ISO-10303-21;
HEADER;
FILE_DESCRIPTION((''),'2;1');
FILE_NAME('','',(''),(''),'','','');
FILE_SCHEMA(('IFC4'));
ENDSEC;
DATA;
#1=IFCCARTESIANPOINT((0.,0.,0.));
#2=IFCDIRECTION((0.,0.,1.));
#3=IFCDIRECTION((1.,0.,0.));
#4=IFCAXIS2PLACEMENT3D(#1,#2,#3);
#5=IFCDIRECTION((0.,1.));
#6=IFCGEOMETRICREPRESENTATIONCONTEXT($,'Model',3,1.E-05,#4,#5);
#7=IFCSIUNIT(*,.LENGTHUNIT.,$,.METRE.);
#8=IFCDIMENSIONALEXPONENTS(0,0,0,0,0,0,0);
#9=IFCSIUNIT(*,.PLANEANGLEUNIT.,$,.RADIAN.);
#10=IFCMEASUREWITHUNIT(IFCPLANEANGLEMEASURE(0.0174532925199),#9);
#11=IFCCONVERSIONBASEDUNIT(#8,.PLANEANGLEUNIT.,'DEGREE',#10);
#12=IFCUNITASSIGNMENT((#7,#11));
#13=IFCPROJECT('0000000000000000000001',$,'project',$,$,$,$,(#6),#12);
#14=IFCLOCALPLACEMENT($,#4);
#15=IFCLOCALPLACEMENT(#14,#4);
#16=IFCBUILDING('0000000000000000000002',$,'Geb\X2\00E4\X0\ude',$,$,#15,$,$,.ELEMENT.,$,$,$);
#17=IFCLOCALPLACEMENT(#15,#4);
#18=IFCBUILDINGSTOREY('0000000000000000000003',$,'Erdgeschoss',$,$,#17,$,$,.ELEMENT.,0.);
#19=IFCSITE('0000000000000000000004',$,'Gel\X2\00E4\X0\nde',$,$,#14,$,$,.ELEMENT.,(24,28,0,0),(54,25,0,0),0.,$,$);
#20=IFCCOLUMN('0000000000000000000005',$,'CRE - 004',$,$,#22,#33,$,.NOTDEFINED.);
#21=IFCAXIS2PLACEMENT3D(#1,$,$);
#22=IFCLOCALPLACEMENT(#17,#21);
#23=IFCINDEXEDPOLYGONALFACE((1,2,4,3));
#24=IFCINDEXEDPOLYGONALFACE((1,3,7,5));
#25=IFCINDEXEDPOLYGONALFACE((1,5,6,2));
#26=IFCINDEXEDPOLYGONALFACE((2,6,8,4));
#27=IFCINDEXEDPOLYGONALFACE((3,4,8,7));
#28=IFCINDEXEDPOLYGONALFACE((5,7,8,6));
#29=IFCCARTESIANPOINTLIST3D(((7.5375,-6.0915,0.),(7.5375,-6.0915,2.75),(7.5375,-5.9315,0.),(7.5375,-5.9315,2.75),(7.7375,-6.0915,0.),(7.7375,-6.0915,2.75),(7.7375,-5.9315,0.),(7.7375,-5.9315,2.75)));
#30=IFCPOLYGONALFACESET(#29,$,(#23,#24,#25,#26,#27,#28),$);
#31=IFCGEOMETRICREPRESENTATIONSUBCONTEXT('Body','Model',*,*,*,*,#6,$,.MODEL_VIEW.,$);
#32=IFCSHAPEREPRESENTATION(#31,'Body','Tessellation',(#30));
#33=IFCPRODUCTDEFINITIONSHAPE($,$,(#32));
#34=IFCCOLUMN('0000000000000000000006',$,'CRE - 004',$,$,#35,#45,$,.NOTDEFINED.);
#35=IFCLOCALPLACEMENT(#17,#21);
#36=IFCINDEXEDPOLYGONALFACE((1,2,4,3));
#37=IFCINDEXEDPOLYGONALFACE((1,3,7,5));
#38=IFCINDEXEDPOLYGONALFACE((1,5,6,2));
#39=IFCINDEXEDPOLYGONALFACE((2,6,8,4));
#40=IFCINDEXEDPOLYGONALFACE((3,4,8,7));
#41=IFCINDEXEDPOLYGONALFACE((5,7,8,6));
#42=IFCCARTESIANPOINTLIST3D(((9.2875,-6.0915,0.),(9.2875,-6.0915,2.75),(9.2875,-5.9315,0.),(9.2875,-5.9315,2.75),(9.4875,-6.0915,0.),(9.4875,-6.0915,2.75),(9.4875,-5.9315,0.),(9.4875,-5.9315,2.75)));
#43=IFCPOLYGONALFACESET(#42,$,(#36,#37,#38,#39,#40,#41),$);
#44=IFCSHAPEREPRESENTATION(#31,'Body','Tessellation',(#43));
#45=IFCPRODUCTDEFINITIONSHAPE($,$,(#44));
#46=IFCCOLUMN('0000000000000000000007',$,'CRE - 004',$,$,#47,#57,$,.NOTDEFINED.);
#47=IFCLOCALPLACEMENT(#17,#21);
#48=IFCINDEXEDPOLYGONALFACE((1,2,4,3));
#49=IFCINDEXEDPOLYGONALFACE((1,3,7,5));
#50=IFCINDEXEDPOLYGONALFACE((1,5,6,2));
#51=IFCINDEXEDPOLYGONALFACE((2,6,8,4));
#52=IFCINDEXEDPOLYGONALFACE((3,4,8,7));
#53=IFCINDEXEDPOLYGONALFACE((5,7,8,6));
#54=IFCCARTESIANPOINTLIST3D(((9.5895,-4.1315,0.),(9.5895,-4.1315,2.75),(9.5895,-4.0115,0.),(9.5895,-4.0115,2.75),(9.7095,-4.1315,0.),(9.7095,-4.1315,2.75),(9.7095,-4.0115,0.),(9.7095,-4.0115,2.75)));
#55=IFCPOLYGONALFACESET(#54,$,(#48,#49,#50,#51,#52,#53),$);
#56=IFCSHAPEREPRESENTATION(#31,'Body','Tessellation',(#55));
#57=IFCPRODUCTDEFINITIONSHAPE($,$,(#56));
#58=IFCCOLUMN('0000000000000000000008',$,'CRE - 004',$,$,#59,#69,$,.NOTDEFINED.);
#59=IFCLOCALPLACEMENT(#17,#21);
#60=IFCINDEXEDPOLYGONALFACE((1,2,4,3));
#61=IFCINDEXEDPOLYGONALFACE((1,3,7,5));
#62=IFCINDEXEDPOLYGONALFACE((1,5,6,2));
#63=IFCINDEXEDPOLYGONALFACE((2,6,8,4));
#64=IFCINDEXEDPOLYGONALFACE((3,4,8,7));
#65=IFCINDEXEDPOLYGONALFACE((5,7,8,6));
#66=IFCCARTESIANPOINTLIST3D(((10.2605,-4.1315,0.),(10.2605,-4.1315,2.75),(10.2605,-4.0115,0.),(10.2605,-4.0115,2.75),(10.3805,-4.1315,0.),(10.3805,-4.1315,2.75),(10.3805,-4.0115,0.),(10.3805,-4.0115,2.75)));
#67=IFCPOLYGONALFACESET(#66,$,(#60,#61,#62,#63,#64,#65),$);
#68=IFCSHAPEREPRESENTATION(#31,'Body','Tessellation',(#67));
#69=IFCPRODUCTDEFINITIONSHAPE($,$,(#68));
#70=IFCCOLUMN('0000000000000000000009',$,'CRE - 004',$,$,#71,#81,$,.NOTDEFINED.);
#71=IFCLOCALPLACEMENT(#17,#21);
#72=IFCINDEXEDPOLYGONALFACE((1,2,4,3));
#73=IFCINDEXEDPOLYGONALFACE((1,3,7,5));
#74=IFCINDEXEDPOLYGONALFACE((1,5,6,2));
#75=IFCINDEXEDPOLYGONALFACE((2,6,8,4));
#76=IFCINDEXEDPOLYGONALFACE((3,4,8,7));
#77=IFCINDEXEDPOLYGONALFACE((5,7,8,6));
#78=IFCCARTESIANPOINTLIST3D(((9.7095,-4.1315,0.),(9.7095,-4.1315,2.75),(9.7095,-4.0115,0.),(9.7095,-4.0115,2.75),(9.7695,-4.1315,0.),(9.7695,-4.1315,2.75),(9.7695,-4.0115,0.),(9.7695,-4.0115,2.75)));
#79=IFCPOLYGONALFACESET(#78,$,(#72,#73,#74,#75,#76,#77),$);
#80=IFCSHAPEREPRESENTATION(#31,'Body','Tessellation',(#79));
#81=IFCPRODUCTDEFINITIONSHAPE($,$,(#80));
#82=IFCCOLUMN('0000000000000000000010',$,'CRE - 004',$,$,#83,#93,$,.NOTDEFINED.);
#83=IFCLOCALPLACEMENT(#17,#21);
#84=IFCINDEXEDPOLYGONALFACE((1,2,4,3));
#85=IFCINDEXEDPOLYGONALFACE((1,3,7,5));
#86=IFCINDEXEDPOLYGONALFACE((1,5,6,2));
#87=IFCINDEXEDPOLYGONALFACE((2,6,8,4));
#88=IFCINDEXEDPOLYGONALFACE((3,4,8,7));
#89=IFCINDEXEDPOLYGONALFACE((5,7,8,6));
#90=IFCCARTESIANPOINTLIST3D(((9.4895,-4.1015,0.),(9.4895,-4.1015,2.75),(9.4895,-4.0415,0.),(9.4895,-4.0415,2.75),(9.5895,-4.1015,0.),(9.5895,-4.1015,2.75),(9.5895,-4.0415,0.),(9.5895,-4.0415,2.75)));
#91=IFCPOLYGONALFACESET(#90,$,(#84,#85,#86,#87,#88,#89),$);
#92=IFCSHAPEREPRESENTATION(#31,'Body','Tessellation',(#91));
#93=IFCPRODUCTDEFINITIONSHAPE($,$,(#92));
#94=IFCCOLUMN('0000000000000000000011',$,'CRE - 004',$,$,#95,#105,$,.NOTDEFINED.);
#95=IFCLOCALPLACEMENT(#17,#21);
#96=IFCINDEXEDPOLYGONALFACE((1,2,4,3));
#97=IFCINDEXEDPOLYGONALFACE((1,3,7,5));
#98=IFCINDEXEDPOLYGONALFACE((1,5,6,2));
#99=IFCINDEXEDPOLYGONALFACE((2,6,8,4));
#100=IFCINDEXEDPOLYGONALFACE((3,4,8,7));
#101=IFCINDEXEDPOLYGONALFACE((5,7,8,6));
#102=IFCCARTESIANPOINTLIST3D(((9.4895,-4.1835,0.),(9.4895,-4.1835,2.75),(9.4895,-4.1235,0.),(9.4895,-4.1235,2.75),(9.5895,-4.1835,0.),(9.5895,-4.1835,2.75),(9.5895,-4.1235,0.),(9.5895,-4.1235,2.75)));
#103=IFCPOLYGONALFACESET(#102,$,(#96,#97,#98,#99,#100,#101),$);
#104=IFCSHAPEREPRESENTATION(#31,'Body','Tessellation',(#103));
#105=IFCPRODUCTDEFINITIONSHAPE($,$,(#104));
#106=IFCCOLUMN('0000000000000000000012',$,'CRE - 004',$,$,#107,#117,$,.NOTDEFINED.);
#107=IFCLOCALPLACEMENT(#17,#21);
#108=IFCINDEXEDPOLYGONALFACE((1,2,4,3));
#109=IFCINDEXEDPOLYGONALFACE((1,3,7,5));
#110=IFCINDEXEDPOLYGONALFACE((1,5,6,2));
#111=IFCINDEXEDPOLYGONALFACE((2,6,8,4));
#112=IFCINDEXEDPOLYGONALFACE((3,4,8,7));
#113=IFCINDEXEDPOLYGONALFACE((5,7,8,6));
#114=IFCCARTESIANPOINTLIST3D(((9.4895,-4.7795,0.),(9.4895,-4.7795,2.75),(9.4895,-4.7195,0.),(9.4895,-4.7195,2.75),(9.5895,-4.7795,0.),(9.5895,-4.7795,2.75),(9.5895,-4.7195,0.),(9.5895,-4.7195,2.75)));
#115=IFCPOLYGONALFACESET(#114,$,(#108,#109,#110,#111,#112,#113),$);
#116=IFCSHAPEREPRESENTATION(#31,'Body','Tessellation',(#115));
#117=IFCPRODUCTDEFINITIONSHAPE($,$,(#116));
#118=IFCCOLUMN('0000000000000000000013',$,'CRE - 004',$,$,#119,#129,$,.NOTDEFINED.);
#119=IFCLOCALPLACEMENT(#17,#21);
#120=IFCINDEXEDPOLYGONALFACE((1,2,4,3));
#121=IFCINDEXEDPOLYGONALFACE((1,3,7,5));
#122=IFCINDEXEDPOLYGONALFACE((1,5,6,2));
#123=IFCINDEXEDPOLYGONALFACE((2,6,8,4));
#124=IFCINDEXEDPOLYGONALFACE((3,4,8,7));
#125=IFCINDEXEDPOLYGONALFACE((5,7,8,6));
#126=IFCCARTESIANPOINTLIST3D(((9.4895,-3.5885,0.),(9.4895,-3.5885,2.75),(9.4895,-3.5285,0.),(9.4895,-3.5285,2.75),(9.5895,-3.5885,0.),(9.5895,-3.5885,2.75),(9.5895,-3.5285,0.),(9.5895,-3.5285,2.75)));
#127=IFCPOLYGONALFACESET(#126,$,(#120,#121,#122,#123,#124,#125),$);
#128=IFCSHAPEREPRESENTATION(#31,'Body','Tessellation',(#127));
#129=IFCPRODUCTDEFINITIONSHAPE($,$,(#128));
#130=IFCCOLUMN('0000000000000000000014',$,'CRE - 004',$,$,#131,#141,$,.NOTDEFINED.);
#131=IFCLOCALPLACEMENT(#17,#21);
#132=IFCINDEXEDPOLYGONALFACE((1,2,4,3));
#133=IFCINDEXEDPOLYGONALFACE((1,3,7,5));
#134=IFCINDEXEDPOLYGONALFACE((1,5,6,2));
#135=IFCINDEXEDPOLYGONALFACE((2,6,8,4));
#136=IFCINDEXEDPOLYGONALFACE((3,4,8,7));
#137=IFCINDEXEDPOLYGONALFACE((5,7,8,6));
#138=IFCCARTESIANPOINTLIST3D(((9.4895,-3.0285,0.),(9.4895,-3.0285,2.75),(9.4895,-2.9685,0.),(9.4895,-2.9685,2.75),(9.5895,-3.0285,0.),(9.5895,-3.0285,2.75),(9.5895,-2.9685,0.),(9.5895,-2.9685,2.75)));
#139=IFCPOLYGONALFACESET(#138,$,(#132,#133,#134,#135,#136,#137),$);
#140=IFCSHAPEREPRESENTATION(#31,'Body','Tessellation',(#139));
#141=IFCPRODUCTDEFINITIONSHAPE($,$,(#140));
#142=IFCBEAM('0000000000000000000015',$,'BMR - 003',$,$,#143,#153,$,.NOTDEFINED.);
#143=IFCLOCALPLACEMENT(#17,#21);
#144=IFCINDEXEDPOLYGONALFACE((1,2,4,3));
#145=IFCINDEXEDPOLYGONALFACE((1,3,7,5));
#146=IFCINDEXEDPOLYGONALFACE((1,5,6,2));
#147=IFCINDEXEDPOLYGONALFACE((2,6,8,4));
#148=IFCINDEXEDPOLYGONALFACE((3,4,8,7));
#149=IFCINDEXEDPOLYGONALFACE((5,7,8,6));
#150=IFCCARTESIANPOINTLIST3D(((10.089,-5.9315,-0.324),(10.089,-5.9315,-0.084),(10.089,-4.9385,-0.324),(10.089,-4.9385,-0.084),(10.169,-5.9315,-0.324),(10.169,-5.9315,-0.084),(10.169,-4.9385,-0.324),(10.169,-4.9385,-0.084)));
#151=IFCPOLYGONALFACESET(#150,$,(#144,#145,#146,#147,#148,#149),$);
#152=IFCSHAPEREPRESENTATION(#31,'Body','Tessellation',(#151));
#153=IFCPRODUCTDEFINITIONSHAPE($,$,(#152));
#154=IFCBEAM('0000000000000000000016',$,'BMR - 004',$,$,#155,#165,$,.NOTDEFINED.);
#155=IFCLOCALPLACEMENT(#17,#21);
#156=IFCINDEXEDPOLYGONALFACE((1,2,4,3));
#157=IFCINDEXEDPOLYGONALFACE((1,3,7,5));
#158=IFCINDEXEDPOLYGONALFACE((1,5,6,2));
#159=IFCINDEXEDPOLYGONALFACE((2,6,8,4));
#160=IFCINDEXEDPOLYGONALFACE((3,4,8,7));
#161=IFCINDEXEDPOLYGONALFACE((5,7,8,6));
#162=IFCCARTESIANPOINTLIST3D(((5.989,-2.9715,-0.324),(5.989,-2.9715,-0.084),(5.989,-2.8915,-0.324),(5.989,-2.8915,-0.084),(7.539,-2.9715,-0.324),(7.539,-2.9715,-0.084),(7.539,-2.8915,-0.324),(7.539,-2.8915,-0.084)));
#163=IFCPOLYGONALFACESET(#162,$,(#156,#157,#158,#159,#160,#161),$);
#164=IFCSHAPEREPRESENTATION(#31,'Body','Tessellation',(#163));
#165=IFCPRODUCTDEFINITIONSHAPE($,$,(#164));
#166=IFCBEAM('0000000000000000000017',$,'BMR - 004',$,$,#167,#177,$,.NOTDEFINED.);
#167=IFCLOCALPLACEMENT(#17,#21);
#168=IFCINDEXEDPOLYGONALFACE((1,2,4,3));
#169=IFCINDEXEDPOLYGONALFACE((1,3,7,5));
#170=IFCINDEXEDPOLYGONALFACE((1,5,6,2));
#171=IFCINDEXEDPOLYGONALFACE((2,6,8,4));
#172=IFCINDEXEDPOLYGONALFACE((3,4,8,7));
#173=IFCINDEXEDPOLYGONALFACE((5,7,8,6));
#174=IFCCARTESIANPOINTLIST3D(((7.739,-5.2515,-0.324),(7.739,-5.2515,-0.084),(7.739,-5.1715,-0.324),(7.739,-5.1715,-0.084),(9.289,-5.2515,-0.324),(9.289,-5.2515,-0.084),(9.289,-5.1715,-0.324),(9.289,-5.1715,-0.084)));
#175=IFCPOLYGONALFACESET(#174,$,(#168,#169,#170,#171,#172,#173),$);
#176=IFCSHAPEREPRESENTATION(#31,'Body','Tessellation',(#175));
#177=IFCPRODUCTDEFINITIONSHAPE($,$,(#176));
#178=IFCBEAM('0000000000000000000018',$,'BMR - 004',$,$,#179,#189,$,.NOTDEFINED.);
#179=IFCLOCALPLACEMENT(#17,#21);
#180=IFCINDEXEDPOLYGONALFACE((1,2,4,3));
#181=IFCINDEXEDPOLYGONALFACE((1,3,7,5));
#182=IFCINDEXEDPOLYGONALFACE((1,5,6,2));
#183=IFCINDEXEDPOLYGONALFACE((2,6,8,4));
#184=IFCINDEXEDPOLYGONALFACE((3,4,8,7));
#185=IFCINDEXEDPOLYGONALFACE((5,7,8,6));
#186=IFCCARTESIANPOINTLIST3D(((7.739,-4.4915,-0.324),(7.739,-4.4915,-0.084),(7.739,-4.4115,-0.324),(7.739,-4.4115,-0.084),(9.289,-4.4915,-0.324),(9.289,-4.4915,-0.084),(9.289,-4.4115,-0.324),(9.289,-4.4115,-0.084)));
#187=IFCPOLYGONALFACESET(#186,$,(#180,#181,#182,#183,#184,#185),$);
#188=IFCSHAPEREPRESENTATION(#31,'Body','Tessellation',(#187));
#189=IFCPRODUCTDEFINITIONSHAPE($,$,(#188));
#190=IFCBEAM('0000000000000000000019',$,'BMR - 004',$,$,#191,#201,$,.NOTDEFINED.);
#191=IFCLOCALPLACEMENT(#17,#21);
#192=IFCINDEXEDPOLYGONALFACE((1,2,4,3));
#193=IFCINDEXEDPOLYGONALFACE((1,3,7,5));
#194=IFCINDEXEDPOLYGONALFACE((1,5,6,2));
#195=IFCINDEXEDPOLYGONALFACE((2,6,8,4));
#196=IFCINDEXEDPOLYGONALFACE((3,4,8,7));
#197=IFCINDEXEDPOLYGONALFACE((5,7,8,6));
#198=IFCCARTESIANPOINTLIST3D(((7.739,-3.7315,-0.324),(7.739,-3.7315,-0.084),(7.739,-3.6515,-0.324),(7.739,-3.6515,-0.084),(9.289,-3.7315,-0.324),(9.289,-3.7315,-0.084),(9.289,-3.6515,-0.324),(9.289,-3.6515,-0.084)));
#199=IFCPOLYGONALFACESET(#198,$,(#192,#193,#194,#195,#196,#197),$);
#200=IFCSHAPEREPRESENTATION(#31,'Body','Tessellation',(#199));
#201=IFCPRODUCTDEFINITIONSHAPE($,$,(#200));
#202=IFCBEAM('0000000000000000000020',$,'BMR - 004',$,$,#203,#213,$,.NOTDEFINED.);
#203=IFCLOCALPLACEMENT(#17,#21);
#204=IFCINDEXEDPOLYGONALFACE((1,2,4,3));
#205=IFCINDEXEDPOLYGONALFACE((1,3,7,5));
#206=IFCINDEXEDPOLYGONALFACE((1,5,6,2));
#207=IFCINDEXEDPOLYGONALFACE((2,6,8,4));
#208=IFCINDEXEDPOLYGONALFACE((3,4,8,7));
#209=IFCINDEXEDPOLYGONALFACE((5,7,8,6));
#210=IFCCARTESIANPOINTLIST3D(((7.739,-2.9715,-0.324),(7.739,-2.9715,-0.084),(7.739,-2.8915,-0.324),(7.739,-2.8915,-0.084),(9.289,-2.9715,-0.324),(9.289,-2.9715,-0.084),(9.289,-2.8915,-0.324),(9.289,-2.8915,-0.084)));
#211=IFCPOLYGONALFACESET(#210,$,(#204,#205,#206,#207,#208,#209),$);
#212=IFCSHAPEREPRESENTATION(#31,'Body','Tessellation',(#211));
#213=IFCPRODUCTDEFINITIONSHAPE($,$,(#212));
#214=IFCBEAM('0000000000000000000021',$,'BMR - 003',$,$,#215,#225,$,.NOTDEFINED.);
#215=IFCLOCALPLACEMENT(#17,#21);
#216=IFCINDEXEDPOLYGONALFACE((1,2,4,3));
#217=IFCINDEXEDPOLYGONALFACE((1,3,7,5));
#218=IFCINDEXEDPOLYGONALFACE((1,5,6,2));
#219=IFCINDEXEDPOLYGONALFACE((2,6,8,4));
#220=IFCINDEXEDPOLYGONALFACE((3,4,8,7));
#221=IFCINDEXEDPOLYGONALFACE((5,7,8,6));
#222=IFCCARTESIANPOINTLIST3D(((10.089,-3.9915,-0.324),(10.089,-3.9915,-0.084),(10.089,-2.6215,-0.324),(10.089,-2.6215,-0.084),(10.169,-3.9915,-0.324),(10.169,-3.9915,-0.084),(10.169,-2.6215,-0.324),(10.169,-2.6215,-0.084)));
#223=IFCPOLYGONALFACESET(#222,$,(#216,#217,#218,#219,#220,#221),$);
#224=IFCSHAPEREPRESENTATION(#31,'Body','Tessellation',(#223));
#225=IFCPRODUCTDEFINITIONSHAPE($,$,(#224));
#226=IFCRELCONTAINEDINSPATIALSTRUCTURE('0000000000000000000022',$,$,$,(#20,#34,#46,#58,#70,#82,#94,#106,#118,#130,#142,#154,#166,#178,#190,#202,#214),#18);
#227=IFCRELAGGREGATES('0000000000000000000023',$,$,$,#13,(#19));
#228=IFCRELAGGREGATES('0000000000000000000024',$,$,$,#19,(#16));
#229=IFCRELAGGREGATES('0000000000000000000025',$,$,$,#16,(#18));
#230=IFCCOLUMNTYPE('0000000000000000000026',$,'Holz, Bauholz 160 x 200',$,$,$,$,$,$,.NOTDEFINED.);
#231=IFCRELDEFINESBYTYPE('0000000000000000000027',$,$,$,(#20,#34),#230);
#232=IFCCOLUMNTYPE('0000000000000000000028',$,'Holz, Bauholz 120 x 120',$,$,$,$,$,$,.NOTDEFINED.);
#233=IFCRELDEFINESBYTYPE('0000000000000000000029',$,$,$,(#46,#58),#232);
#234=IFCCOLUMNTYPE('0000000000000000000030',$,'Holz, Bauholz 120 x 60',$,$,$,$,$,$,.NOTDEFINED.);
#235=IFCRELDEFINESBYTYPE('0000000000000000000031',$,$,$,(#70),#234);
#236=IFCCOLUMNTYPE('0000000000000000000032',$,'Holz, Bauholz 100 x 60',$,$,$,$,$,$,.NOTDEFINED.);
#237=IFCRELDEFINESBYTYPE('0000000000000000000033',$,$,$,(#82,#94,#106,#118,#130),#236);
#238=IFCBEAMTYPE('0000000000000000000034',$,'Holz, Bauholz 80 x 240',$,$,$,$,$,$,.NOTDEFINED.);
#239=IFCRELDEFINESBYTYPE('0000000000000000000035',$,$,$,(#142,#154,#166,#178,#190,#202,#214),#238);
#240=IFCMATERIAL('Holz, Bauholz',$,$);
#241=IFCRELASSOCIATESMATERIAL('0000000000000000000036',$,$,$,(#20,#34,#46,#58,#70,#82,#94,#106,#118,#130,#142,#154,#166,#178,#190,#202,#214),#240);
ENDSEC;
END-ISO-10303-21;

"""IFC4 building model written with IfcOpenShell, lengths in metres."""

from ifc_helpers import new_model, entity, si_unit, converted_unit, direction, frame, frame_2d, origin_with_axes, origin_2d_with_axis, place, context, subcontext, project, spatial, rectangle, extrude, material, type_object, element, save


model = new_model("IFC4")

# Units and contexts
model_context = context("Model", 3, precision=1e-05, world=origin_with_axes(), true_north=direction((0.0, 1.0)))
body_context = subcontext(model_context, "Body", "Model", "MODEL_VIEW")
ifc_project = project(units=[si_unit("LENGTHUNIT", "METRE"), converted_unit("PLANEANGLEUNIT", "DEGREE", entity("IfcPlaneAngleMeasure", 0.0174532925199), si_unit("PLANEANGLEUNIT", "RADIAN"), dimensions=[0, 0, 0, 0, 0, 0, 0])], contexts=[model_context])

# Site, building, storey
site_placement = place(None, origin_with_axes())
site = spatial("IfcSite", under=ifc_project, at=site_placement, Name="Gelände", CompositionType="ELEMENT", RefLatitude=(24, 28, 0, 0), RefLongitude=(54, 25, 0, 0), RefElevation=0.0)
building_placement = place(site_placement, origin_with_axes())
building = spatial("IfcBuilding", under=site, at=building_placement, Name="Gebäude", CompositionType="ELEMENT")
storey_placement = place(building_placement, origin_with_axes())
storey = spatial("IfcBuildingStorey", under=building, at=storey_placement, Name="Erdgeschoss", CompositionType="ELEMENT", Elevation=0.0)

# Columns
ifc_material_1 = material(Name="Holz, Bauholz")
column_type_1 = type_object("IfcColumnType", Name="Holz, Bauholz 160 x 200", PredefinedType="NOTDEFINED")
for number, where, z_axis, x_axis, name in (
    (1, (7.6375, -6.0115, 0.0), (0.0, 0.0, 1.0), (1.0, 0.0, 0.0), "CRE - 004"),
    (2, (9.3875, -6.0115, 0.0), (0.0, 0.0, 1.0), (1.0, 0.0, 0.0), "CRE - 004"),
):
    element("IfcColumn", number, at=place(storey_placement, frame(where, z_axis=z_axis, x_axis=x_axis)), inside=storey, type_object=column_type_1, material=ifc_material_1, Name=name, PredefinedType="NOTDEFINED", context=body_context, shape_type="SweptSolid", body=[
        extrude(rectangle(XDim=0.16, YDim=0.2, at=origin_2d_with_axis()), frame((0.0, 0.0, 0.0), z_axis=(0.0, 0.0, 1.0), x_axis=(0.0, 1.0, 0.0)), (0.0, 0.0, 1.0), 2.75),
    ])
column_type_2 = type_object("IfcColumnType", Name="Holz, Bauholz 120 x 120", PredefinedType="NOTDEFINED")
for number, where, z_axis, x_axis, name in (
    (3, (9.6495, -4.0715, 0.0), (0.0, 0.0, 1.0), (1.0, 0.0, 0.0), "CRE - 004"),
    (4, (10.3205, -4.0715, 0.0), (0.0, 0.0, 1.0), (1.0, 0.0, 0.0), "CRE - 004"),
):
    element("IfcColumn", number, at=place(storey_placement, frame(where, z_axis=z_axis, x_axis=x_axis)), inside=storey, type_object=column_type_2, material=ifc_material_1, Name=name, PredefinedType="NOTDEFINED", context=body_context, shape_type="SweptSolid", body=[
        extrude(rectangle(XDim=0.12, YDim=0.12, at=origin_2d_with_axis()), frame((0.0, 0.0, 0.0), z_axis=(0.0, 0.0, 1.0), x_axis=(0.0, 1.0, 0.0)), (0.0, 0.0, 1.0), 2.75),
    ])
column_type_3 = type_object("IfcColumnType", Name="Holz, Bauholz 120 x 60", PredefinedType="NOTDEFINED")
column_placement = place(storey_placement, frame((9.7395, -4.0715, 0.0), z_axis=(0.0, 0.0, 1.0), x_axis=(1.0, 0.0, 0.0)))
element("IfcColumn", 5, at=column_placement, inside=storey, type_object=column_type_3, material=ifc_material_1, Name="CRE - 004", PredefinedType="NOTDEFINED", context=body_context, shape_type="SweptSolid", body=[
    extrude(rectangle(XDim=0.12, YDim=0.06, at=origin_2d_with_axis()), frame((0.0, 0.0, 0.0), z_axis=(0.0, 0.0, 1.0), x_axis=(0.0, 1.0, 0.0)), (0.0, 0.0, 1.0), 2.75),
])
column_type_4 = type_object("IfcColumnType", Name="Holz, Bauholz 100 x 60", PredefinedType="NOTDEFINED")
for number, where, z_axis, x_axis, name in (
    (6, (9.5395, -4.0715, 0.0), (0.0, 0.0, 1.0), (0.0, -1.0, 0.0), "CRE - 004"),
    (7, (9.5395, -4.1535, 0.0), (0.0, 0.0, 1.0), (0.0, -1.0, 0.0), "CRE - 004"),
    (8, (9.5395, -4.7495, 0.0), (0.0, 0.0, 1.0), (0.0, -1.0, 0.0), "CRE - 004"),
    (9, (9.5395, -3.5585, 0.0), (0.0, 0.0, 1.0), (0.0, -1.0, 0.0), "CRE - 004"),
    (10, (9.5395, -2.9985, 0.0), (0.0, 0.0, 1.0), (0.0, -1.0, 0.0), "CRE - 004"),
):
    element("IfcColumn", number, at=place(storey_placement, frame(where, z_axis=z_axis, x_axis=x_axis)), inside=storey, type_object=column_type_4, material=ifc_material_1, Name=name, PredefinedType="NOTDEFINED", context=body_context, shape_type="SweptSolid", body=[
        extrude(rectangle(XDim=0.1, YDim=0.06, at=origin_2d_with_axis()), frame((0.0, 0.0, 0.0), z_axis=(0.0, 0.0, 1.0), x_axis=(0.0, 1.0, 0.0)), (0.0, 0.0, 1.0), 2.75),
    ])

# Beams
beam_type_1 = type_object("IfcBeamType", Name="Holz, Bauholz 80 x 240", PredefinedType="NOTDEFINED")
beam_1_placement = place(storey_placement, frame((10.129, -5.9315, -0.084), z_axis=(0.0, 0.0, 1.0), x_axis=(1.0, 0.0, 0.0)))
element("IfcBeam", 11, at=beam_1_placement, inside=storey, type_object=beam_type_1, material=ifc_material_1, Name="BMR - 003", PredefinedType="NOTDEFINED", context=body_context, shape_type="SweptSolid", body=[
    extrude(rectangle(XDim=0.24, YDim=0.08, at=frame_2d((-0.12, 0.0), x_axis=(1.0, 0.0))), frame((0.0, 0.0, 0.0), z_axis=(0.0, 1.0, 0.0), x_axis=(0.0, 0.0, 1.0)), (0.0, 0.0, 1.0), 0.993),
])
for number, where, z_axis, x_axis, name in (
    (12, (7.539, -2.9315, -0.084), (0.0, 0.0, 1.0), (0.0, 1.0, 0.0), "BMR - 004"),
    (13, (9.289, -5.2115, -0.084), (0.0, 0.0, 1.0), (0.0, 1.0, 0.0), "BMR - 004"),
    (14, (9.289, -4.4515, -0.084), (0.0, 0.0, 1.0), (0.0, 1.0, 0.0), "BMR - 004"),
    (15, (9.289, -3.6915, -0.084), (0.0, 0.0, 1.0), (0.0, 1.0, 0.0), "BMR - 004"),
    (16, (9.289, -2.9315, -0.084), (0.0, 0.0, 1.0), (0.0, 1.0, 0.0), "BMR - 004"),
):
    element("IfcBeam", number, at=place(storey_placement, frame(where, z_axis=z_axis, x_axis=x_axis)), inside=storey, type_object=beam_type_1, material=ifc_material_1, Name=name, PredefinedType="NOTDEFINED", context=body_context, shape_type="SweptSolid", body=[
        extrude(rectangle(XDim=0.24, YDim=0.08, at=frame_2d((-0.12, 0.0), x_axis=(1.0, 0.0))), frame((0.0, 0.0, 0.0), z_axis=(0.0, 1.0, 0.0), x_axis=(0.0, 0.0, 1.0)), (0.0, 0.0, 1.0), 1.55),
    ])
beam_2_placement = place(storey_placement, frame((10.129, -3.9915, -0.084), z_axis=(0.0, 0.0, 1.0), x_axis=(1.0, 0.0, 0.0)))
element("IfcBeam", 17, at=beam_2_placement, inside=storey, type_object=beam_type_1, material=ifc_material_1, Name="BMR - 003", PredefinedType="NOTDEFINED", context=body_context, shape_type="SweptSolid", body=[
    extrude(rectangle(XDim=0.24, YDim=0.08, at=frame_2d((-0.12, 0.0), x_axis=(1.0, 0.0))), frame((0.0, 0.0, 0.0), z_axis=(0.0, 1.0, 0.0), x_axis=(0.0, 0.0, 1.0)), (0.0, 0.0, 1.0), 1.37),
])

save(model, "model.ifc")
